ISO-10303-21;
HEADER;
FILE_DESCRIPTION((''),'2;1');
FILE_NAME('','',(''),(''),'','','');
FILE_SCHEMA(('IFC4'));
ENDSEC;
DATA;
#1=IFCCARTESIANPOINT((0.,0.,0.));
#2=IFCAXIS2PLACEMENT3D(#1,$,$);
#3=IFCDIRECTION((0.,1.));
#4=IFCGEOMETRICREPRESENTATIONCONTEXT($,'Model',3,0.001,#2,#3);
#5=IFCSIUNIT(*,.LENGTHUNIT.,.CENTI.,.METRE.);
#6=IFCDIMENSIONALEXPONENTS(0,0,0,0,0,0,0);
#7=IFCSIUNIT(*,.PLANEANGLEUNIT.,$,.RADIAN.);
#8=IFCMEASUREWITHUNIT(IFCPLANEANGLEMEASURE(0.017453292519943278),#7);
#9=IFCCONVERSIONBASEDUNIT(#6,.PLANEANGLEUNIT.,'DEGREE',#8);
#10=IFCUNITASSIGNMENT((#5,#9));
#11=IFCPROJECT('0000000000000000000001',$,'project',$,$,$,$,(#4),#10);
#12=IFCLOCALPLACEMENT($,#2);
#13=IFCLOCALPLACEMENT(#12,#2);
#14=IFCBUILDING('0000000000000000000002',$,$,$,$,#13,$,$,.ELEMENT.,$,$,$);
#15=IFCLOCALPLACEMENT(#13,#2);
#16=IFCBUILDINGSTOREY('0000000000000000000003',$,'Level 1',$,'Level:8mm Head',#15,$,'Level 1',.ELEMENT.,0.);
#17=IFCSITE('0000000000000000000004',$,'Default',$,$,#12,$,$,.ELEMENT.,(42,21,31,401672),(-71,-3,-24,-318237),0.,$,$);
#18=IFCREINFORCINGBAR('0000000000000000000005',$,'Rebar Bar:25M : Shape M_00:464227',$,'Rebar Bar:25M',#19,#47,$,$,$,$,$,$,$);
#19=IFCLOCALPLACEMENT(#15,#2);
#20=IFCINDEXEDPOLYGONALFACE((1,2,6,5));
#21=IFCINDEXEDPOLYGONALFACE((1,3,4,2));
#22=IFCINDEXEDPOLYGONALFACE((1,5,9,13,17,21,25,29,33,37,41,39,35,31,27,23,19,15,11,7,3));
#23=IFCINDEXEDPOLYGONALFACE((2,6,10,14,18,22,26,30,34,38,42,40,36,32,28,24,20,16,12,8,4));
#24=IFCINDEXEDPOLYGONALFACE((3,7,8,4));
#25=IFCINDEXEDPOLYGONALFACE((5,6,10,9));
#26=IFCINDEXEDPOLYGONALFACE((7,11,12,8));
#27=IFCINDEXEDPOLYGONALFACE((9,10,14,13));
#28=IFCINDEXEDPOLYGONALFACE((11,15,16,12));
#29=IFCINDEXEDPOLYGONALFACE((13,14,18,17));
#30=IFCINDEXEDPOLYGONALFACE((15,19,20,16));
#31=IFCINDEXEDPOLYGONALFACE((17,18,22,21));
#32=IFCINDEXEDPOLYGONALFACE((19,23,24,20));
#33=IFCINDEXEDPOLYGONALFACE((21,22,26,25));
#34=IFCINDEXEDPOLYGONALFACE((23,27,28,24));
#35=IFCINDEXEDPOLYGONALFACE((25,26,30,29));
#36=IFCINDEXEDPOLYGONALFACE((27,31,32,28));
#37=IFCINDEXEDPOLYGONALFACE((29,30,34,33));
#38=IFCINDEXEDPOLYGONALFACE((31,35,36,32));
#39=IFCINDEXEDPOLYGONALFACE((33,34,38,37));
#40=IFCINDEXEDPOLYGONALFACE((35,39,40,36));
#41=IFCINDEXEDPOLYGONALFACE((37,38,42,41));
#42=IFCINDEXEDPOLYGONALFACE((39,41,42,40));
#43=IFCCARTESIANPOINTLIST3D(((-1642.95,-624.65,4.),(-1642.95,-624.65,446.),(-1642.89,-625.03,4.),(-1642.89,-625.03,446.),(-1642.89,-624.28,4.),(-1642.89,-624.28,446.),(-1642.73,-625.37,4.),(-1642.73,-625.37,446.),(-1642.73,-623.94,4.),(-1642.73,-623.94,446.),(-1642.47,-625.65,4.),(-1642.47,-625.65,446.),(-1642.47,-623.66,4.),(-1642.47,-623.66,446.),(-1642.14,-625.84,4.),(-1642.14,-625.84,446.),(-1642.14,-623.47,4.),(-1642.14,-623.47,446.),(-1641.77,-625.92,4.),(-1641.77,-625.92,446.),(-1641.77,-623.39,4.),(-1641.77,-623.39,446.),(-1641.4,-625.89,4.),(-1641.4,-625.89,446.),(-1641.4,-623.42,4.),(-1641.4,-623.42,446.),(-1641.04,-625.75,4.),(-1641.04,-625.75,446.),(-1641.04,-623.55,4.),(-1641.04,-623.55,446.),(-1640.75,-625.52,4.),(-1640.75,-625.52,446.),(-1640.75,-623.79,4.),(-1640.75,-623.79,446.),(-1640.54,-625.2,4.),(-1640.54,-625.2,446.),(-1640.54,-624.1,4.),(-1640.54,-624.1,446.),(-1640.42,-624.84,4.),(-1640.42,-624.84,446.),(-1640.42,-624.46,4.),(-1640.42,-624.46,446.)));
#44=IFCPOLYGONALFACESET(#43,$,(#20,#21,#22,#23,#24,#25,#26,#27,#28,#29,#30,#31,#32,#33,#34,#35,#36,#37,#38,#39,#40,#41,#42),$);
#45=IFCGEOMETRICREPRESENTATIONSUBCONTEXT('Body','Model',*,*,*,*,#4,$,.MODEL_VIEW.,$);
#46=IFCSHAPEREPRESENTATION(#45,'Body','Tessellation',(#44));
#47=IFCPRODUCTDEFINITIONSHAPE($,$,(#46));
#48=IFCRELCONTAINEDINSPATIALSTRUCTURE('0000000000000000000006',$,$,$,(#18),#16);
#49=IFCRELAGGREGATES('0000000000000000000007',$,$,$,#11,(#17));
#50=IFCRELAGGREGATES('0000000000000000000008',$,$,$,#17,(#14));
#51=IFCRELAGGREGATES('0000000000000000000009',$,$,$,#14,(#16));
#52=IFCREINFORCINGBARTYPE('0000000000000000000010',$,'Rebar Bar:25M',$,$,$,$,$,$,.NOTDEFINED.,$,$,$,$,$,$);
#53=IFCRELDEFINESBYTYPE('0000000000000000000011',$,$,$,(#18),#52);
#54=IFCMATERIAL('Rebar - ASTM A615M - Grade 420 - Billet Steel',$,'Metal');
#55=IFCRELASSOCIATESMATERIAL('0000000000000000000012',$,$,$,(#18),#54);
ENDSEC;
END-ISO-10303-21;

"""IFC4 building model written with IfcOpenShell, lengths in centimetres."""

from ifc_helpers import new_model, entity, si_unit, converted_unit, direction, origin, place, context, subcontext, project, spatial, material, type_object, element, save


model = new_model("IFC4")

# Units and contexts
model_context = context("Model", 3, precision=0.001, world=origin(), true_north=direction((0.0, 1.0)))
body_context = subcontext(model_context, "Body", "Model", "MODEL_VIEW")
ifc_project = project(units=[si_unit("LENGTHUNIT", "METRE", prefix="CENTI"), converted_unit("PLANEANGLEUNIT", "DEGREE", entity("IfcPlaneAngleMeasure", 0.017453292519943278), si_unit("PLANEANGLEUNIT", "RADIAN"), dimensions=[0, 0, 0, 0, 0, 0, 0])], contexts=[model_context])

# Site, building, storey
site_placement = place(None, origin())
site = spatial("IfcSite", under=ifc_project, at=site_placement, Name="Default", CompositionType="ELEMENT", RefLatitude=(42, 21, 31, 401672), RefLongitude=(-71, -3, -24, -318237), RefElevation=0.0)
building_placement = place(site_placement, origin())
building = spatial("IfcBuilding", under=site, at=building_placement, CompositionType="ELEMENT")
storey_placement = place(building_placement, origin())
storey = spatial("IfcBuildingStorey", under=building, at=storey_placement, Name="Level 1", ObjectType="Level:8mm Head", LongName="Level 1", CompositionType="ELEMENT", Elevation=0.0)

# Reinforcing bar
ifc_material = material(Name="Rebar - ASTM A615M - Grade 420 - Billet Steel", Category="Metal")
reinforcing_bar_type_1 = type_object("IfcReinforcingBarType", Name="Rebar Bar:25M", PredefinedType="NOTDEFINED")
reinforcing_bar_1_placement = place(storey_placement, origin())
element("IfcReinforcingBar", 1, at=reinforcing_bar_1_placement, inside=storey, type_object=reinforcing_bar_type_1, material=ifc_material, Name="Rebar Bar:25M : Shape M_00:464227", ObjectType="Rebar Bar:25M", context=body_context, shape_type="AdvancedSweptSolid", body=[
    entity("IfcSweptDiskSolid", entity("IfcIndexedPolyCurve", entity("IfcCartesianPointList3D", [[-1641.68, -624.65, 446.0], [-1641.68, -624.65, 4.0]]), None, False), 1.27, None, 0.0, 1.0),
])

save(model, "model.ifc")
